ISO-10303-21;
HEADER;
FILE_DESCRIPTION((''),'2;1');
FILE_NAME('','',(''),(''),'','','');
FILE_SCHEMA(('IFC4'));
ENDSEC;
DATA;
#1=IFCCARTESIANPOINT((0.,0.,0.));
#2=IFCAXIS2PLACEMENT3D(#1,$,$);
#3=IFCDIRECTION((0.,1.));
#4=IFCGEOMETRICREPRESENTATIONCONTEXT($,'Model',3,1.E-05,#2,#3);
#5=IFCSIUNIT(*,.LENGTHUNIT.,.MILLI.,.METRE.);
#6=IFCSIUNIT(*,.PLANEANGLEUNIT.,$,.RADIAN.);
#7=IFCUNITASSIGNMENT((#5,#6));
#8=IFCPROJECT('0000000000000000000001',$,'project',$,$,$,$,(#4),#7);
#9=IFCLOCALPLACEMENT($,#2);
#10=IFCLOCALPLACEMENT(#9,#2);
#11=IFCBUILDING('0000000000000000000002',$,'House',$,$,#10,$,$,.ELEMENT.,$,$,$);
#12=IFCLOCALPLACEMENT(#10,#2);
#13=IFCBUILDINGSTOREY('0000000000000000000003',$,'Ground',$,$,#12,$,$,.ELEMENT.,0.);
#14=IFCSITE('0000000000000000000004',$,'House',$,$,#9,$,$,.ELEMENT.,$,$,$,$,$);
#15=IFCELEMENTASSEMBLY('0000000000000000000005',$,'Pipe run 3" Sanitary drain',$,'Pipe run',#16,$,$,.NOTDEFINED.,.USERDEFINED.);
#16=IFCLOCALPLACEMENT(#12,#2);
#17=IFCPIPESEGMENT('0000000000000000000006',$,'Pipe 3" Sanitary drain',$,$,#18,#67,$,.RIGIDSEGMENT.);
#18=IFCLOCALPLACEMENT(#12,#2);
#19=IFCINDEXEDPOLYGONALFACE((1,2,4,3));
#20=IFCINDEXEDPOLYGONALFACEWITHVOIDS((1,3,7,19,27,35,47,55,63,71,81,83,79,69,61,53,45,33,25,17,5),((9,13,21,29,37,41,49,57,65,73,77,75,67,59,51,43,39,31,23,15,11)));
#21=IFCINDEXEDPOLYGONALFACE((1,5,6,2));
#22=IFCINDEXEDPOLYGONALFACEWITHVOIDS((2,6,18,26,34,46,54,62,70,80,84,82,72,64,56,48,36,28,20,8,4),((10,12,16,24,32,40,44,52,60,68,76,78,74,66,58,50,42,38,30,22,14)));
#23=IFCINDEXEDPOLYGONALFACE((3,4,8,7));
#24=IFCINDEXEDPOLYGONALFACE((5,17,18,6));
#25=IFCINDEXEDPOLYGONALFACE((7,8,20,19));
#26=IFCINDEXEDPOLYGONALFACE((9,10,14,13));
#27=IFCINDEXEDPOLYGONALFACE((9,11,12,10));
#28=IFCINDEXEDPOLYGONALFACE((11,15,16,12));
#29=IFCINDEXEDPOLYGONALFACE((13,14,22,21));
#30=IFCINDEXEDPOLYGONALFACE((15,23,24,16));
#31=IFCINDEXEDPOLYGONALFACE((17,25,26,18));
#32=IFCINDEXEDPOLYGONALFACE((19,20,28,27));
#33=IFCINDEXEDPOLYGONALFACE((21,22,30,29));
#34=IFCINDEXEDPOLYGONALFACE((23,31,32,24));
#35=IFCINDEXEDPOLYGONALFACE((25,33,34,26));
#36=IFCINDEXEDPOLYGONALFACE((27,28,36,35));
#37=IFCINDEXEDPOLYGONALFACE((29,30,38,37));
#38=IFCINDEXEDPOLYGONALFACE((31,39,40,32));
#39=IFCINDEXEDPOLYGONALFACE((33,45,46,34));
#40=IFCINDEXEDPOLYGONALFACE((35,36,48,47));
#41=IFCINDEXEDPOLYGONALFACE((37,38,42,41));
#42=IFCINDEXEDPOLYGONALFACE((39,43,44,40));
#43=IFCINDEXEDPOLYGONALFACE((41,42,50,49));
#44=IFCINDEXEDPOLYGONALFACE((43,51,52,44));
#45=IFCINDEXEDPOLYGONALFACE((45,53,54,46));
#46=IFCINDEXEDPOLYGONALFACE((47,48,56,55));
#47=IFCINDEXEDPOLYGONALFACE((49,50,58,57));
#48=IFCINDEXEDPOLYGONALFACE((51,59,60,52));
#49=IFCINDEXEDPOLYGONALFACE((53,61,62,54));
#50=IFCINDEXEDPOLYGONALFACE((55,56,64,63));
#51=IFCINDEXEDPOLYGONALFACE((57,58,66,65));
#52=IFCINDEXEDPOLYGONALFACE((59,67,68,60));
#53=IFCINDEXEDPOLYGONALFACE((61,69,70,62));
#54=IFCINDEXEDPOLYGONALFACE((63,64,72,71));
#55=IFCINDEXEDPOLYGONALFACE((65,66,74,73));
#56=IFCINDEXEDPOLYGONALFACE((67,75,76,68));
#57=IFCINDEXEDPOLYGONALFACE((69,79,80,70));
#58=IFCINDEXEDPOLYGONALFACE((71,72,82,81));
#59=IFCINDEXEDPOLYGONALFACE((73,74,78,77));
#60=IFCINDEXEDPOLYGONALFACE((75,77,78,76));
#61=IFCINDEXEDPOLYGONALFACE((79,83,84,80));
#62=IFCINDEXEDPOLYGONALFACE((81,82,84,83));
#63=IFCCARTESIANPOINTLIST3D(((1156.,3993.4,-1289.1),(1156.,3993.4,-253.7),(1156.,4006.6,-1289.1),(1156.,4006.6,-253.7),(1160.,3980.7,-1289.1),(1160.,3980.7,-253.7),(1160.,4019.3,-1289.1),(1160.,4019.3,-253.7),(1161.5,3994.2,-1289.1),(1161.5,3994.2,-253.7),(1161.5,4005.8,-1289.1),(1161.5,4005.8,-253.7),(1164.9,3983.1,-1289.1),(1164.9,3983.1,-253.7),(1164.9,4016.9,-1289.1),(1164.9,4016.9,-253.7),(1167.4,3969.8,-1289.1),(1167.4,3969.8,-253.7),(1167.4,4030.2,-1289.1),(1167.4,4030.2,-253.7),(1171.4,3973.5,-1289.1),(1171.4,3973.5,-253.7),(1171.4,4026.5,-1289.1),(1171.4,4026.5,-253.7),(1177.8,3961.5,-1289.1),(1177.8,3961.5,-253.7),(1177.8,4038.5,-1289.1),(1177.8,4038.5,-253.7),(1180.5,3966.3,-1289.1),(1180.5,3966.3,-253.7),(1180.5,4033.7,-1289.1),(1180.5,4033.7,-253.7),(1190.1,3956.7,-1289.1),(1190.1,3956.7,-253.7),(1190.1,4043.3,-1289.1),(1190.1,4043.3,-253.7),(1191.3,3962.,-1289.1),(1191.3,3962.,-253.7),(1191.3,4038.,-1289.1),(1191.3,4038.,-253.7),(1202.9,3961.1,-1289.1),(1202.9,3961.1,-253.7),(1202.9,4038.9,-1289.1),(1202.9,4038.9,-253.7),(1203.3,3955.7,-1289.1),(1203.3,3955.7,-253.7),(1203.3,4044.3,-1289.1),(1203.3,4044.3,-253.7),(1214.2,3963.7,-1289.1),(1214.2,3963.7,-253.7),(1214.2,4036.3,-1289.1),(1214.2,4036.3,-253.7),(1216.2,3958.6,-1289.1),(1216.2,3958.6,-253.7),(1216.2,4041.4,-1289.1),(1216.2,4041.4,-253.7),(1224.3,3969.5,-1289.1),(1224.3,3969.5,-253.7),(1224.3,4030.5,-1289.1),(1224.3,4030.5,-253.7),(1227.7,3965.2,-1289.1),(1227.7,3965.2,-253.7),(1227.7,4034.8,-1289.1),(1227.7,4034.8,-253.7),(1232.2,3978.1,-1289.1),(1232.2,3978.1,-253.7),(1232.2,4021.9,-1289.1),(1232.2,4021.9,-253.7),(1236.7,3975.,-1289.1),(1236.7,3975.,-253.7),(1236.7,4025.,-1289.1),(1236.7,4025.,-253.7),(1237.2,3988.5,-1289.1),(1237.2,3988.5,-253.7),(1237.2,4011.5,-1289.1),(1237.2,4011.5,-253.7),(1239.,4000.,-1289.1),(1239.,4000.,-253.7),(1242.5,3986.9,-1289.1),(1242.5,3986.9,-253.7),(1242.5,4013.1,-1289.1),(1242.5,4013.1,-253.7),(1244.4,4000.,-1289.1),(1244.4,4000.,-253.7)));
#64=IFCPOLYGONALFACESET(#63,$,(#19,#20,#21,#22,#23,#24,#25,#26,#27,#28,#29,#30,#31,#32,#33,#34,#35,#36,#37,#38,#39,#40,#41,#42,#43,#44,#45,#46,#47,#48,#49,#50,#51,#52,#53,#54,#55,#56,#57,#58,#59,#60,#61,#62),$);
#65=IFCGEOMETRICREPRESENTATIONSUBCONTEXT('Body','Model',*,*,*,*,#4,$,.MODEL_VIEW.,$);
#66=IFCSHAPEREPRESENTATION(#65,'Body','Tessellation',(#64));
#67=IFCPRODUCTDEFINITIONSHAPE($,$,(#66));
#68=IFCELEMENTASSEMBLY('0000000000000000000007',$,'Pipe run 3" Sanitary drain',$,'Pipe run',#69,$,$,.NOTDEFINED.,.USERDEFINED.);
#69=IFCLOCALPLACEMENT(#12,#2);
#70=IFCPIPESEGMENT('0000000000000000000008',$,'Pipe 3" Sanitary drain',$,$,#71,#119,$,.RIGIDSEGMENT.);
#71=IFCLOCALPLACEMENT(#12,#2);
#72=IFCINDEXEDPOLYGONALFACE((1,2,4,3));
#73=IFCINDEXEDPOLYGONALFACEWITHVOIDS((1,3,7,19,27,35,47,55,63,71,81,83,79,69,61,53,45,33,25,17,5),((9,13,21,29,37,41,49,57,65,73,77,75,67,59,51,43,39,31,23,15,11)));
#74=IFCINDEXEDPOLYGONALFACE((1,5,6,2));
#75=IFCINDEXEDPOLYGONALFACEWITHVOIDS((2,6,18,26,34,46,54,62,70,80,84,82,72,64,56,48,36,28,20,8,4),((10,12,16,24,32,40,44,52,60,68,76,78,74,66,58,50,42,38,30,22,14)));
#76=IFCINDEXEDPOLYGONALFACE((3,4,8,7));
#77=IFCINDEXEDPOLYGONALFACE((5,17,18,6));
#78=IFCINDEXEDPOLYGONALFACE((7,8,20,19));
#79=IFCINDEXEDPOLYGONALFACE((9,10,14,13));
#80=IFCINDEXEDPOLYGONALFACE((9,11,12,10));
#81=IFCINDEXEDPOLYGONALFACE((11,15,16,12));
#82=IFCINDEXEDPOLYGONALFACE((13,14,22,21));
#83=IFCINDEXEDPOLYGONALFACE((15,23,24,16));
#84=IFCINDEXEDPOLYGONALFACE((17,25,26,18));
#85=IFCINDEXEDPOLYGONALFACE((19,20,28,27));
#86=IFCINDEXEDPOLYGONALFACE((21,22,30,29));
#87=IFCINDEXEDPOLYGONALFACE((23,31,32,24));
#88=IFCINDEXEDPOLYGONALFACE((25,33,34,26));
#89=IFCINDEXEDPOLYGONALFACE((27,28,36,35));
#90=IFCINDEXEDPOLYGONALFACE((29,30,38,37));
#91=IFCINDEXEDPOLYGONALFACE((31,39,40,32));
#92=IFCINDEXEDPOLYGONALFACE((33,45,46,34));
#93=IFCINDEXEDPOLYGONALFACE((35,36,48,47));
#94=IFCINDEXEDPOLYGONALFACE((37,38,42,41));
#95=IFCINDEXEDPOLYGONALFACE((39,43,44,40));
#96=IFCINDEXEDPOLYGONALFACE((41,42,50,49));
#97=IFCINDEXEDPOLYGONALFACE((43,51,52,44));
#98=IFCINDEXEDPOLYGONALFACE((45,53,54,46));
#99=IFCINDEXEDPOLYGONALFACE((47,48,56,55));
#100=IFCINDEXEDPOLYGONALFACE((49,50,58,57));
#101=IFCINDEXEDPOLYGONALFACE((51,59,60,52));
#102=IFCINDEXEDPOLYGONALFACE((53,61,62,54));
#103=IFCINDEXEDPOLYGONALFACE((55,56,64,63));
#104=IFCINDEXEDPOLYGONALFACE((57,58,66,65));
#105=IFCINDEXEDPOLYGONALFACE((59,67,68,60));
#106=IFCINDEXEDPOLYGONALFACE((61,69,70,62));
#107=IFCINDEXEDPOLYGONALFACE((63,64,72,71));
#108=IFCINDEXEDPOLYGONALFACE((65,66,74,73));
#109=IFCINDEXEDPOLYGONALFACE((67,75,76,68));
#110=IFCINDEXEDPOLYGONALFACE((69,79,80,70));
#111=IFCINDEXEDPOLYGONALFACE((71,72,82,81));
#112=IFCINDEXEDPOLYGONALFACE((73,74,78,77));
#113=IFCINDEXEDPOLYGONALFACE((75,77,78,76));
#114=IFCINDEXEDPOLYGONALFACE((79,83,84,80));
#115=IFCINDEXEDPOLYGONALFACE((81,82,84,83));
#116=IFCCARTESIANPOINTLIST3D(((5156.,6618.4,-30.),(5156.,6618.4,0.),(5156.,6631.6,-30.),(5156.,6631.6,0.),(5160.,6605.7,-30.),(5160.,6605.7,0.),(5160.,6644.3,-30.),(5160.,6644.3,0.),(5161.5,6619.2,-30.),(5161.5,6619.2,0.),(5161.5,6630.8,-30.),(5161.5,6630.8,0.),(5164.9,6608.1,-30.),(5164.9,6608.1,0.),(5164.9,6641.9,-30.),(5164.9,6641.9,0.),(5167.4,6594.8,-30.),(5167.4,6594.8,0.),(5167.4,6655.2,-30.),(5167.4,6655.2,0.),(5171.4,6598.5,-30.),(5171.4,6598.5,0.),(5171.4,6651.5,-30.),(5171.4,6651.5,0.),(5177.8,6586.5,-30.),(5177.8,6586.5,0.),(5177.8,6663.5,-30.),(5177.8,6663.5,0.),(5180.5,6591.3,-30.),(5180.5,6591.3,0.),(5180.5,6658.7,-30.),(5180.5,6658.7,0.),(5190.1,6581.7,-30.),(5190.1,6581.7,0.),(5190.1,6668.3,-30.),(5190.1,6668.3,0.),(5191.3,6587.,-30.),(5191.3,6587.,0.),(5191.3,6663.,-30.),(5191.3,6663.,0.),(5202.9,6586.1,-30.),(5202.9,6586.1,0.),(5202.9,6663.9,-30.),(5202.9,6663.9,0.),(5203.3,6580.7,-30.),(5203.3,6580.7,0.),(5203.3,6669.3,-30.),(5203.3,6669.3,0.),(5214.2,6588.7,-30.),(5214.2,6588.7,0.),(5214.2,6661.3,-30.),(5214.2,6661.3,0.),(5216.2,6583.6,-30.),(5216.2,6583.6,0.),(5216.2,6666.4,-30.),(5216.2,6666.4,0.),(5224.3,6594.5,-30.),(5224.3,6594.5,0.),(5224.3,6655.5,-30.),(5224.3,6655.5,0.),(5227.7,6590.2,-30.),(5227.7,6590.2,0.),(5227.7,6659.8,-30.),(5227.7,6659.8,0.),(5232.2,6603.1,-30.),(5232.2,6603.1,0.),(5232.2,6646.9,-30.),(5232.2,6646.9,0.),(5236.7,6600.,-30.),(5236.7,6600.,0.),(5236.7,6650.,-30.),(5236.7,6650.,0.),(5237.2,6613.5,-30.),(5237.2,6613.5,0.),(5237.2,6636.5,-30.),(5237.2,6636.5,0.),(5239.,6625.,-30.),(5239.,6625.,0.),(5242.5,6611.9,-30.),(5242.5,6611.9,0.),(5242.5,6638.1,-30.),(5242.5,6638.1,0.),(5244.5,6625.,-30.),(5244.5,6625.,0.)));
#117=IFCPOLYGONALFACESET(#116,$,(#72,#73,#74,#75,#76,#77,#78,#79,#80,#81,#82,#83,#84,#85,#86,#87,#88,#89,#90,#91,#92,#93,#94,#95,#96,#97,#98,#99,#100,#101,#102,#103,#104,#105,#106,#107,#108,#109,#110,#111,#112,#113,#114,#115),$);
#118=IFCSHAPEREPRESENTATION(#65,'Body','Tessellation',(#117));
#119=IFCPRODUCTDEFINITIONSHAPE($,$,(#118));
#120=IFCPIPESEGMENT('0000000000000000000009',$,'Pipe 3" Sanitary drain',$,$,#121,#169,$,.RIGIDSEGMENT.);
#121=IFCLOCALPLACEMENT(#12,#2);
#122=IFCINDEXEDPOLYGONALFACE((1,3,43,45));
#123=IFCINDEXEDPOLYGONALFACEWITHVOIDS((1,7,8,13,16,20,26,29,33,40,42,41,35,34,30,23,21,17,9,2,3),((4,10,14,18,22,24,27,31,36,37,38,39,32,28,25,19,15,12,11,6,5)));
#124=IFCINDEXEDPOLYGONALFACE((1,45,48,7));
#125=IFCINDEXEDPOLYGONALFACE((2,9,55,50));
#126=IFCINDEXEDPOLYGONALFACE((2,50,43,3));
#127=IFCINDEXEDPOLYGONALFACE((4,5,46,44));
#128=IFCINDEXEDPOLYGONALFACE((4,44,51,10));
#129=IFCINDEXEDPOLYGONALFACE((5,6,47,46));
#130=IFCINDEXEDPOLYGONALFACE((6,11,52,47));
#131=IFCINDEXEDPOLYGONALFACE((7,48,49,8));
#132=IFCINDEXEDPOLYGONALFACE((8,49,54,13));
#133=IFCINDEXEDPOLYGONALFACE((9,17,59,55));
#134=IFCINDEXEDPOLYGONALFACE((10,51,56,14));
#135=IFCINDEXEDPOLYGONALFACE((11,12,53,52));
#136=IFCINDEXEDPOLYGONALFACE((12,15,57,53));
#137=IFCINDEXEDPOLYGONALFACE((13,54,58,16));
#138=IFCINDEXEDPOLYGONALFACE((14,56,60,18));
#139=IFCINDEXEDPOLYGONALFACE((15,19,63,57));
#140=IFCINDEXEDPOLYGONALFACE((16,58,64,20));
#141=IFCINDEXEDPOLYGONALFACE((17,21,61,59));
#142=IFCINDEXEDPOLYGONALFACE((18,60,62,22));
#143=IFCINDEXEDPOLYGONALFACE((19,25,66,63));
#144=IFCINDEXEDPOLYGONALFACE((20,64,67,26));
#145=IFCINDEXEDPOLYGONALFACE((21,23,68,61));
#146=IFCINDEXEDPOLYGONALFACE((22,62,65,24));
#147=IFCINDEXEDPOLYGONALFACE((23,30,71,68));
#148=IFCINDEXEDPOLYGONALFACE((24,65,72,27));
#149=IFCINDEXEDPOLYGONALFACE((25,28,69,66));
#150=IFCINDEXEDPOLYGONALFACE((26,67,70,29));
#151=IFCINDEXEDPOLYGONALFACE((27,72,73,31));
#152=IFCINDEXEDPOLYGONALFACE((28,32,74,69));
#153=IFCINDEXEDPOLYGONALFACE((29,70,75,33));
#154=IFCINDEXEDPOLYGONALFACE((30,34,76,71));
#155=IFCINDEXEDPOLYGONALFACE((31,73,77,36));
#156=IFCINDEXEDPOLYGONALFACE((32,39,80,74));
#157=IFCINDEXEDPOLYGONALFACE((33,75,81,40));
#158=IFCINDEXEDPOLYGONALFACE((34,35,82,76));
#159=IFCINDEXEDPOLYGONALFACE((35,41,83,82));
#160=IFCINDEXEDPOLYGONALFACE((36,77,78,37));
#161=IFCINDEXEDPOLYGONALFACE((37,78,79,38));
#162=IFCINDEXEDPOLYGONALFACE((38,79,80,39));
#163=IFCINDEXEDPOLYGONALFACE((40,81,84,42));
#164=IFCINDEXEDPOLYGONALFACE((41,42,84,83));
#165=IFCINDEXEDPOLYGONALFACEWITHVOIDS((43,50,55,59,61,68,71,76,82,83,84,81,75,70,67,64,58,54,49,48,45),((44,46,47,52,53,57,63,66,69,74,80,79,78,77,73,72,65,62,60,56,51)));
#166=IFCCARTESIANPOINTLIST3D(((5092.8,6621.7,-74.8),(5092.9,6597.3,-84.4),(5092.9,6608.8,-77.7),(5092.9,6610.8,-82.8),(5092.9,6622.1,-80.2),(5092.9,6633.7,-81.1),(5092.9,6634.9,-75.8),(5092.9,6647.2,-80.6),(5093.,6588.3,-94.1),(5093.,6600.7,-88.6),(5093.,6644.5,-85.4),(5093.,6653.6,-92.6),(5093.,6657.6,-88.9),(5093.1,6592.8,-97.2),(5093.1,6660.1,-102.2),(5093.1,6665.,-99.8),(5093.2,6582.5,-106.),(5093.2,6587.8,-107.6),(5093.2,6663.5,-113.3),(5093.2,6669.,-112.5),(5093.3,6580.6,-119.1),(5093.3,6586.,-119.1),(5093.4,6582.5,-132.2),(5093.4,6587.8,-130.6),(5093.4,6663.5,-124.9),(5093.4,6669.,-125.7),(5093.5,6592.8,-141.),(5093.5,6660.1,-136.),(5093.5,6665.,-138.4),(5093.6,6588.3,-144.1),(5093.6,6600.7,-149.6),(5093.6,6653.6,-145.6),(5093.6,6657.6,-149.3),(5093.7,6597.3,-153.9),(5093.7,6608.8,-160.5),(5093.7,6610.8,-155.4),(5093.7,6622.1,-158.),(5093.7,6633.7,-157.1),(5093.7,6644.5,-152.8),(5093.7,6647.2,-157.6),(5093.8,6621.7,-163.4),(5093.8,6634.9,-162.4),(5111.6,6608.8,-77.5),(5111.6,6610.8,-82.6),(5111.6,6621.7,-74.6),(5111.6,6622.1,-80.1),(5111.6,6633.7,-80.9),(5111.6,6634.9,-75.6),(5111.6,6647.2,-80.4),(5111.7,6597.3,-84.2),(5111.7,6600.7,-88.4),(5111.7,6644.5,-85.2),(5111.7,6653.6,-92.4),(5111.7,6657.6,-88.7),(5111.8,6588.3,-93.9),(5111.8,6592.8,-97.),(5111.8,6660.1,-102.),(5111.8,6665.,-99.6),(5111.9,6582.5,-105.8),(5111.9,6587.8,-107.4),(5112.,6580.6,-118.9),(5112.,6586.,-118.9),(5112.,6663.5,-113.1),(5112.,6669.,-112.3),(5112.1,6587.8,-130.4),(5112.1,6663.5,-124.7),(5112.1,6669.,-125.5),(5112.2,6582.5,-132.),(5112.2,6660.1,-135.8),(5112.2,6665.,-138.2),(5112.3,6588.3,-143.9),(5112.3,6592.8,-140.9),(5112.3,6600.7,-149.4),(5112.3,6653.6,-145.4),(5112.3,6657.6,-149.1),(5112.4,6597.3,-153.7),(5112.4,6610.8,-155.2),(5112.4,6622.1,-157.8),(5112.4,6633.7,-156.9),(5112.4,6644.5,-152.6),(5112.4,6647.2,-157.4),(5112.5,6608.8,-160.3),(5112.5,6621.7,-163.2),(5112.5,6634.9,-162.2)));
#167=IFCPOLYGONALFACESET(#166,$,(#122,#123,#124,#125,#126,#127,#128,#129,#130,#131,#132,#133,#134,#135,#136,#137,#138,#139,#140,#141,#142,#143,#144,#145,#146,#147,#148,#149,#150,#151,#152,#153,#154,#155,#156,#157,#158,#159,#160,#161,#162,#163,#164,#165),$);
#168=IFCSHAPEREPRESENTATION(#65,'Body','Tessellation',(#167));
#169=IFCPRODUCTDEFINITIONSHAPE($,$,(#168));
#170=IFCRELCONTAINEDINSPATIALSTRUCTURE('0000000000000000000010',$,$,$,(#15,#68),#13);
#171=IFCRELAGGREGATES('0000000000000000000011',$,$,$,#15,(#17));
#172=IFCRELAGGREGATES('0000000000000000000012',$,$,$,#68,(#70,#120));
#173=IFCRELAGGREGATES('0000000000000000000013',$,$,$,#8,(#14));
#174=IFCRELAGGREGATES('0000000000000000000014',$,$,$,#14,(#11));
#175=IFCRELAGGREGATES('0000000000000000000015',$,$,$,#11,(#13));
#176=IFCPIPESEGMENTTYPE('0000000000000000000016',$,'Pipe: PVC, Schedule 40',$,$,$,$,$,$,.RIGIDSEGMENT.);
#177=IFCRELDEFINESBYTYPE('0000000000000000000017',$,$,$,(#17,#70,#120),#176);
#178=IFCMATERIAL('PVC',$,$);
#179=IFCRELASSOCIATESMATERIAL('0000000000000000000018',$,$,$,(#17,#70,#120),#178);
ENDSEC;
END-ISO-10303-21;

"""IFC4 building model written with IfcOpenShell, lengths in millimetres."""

from ifc_helpers import new_model, si_unit, direction, frame, origin, origin_with_axes, origin_2d, place, context, subcontext, project, spatial, hollow_circle, extrude, material, type_object, element, aggregate, save


model = new_model("IFC4")

# Units and contexts
model_context = context("Model", 3, precision=1e-05, world=origin(), true_north=direction((0.0, 1.0)))
body_context = subcontext(model_context, "Body", "Model", "MODEL_VIEW")
ifc_project = project(units=[si_unit("LENGTHUNIT", "METRE", prefix="MILLI"), si_unit("PLANEANGLEUNIT", "RADIAN")], contexts=[model_context])

# Site, building, storey
site_placement = place(None, origin())
site = spatial("IfcSite", under=ifc_project, at=site_placement, Name="House", CompositionType="ELEMENT")
building_placement = place(site_placement, origin())
building = spatial("IfcBuilding", under=site, at=building_placement, Name="House", CompositionType="ELEMENT")
storey_placement = place(building_placement, origin())
storey = spatial("IfcBuildingStorey", under=building, at=storey_placement, Name="Ground", CompositionType="ELEMENT", Elevation=0.0)

# Element assemblies, pipe segments
ifc_material = material(Name="PVC")
pipe_segment_type = type_object("IfcPipeSegmentType", Name="Pipe: PVC, Schedule 40", PredefinedType="RIGIDSEGMENT")
assembly_1_placement = place(storey_placement, origin_with_axes())
assembly_1 = element("IfcElementAssembly", 1, at=assembly_1_placement, inside=storey, Name="Pipe run 3\" Sanitary drain", ObjectType="Pipe run", AssemblyPlace="NOTDEFINED", PredefinedType="USERDEFINED")
pipe_segment_1_placement = place(storey_placement, origin_with_axes())
pipe_segment_1 = element("IfcPipeSegment", 2, at=pipe_segment_1_placement, type_object=pipe_segment_type, material=ifc_material, Name="Pipe 3\" Sanitary drain", PredefinedType="RIGIDSEGMENT", context=body_context, shape_type="SweptSolid", body=[
    extrude(hollow_circle(Radius=44.5, WallThickness=5.5, at=origin_2d()), frame((1200.0, 4000.0, -253.7), z_axis=(0.0, 0.0, -1.0), x_axis=(1.0, 0.0, 0.0)), (0.0, 0.0, 1.0), 1035.4),
])
assembly_2_placement = place(storey_placement, origin_with_axes())
assembly_2 = element("IfcElementAssembly", 3, at=assembly_2_placement, inside=storey, Name="Pipe run 3\" Sanitary drain", ObjectType="Pipe run", AssemblyPlace="NOTDEFINED", PredefinedType="USERDEFINED")
pipe_segment_2_placement = place(storey_placement, origin_with_axes())
pipe_segment_2 = element("IfcPipeSegment", 4, at=pipe_segment_2_placement, type_object=pipe_segment_type, material=ifc_material, Name="Pipe 3\" Sanitary drain", PredefinedType="RIGIDSEGMENT", context=body_context, shape_type="SweptSolid", body=[
    extrude(hollow_circle(Radius=44.5, WallThickness=5.5, at=origin_2d()), frame((5200.0, 6625.0, 0.0), z_axis=(0.0, 0.0, -1.0), x_axis=(1.0, 0.0, 0.0)), (0.0, 0.0, 1.0), 30.0),
])
pipe_segment_3_placement = place(storey_placement, origin_with_axes())
pipe_segment_3 = element("IfcPipeSegment", 5, at=pipe_segment_3_placement, type_object=pipe_segment_type, material=ifc_material, Name="Pipe 3\" Sanitary drain", PredefinedType="RIGIDSEGMENT", context=body_context, shape_type="SweptSolid", body=[
    extrude(hollow_circle(Radius=44.5, WallThickness=5.5, at=origin_2d()), frame((5112.0, 6625.0, -118.9), z_axis=(-0.999946, 0.0, -0.010416), x_axis=(0.0, -1.0, 0.0)), (0.0, 0.0, 1.0), 18.7),
])

aggregate(assembly_1, [pipe_segment_1])
aggregate(assembly_2, [pipe_segment_2, pipe_segment_3])

save(model, "model.ifc")
